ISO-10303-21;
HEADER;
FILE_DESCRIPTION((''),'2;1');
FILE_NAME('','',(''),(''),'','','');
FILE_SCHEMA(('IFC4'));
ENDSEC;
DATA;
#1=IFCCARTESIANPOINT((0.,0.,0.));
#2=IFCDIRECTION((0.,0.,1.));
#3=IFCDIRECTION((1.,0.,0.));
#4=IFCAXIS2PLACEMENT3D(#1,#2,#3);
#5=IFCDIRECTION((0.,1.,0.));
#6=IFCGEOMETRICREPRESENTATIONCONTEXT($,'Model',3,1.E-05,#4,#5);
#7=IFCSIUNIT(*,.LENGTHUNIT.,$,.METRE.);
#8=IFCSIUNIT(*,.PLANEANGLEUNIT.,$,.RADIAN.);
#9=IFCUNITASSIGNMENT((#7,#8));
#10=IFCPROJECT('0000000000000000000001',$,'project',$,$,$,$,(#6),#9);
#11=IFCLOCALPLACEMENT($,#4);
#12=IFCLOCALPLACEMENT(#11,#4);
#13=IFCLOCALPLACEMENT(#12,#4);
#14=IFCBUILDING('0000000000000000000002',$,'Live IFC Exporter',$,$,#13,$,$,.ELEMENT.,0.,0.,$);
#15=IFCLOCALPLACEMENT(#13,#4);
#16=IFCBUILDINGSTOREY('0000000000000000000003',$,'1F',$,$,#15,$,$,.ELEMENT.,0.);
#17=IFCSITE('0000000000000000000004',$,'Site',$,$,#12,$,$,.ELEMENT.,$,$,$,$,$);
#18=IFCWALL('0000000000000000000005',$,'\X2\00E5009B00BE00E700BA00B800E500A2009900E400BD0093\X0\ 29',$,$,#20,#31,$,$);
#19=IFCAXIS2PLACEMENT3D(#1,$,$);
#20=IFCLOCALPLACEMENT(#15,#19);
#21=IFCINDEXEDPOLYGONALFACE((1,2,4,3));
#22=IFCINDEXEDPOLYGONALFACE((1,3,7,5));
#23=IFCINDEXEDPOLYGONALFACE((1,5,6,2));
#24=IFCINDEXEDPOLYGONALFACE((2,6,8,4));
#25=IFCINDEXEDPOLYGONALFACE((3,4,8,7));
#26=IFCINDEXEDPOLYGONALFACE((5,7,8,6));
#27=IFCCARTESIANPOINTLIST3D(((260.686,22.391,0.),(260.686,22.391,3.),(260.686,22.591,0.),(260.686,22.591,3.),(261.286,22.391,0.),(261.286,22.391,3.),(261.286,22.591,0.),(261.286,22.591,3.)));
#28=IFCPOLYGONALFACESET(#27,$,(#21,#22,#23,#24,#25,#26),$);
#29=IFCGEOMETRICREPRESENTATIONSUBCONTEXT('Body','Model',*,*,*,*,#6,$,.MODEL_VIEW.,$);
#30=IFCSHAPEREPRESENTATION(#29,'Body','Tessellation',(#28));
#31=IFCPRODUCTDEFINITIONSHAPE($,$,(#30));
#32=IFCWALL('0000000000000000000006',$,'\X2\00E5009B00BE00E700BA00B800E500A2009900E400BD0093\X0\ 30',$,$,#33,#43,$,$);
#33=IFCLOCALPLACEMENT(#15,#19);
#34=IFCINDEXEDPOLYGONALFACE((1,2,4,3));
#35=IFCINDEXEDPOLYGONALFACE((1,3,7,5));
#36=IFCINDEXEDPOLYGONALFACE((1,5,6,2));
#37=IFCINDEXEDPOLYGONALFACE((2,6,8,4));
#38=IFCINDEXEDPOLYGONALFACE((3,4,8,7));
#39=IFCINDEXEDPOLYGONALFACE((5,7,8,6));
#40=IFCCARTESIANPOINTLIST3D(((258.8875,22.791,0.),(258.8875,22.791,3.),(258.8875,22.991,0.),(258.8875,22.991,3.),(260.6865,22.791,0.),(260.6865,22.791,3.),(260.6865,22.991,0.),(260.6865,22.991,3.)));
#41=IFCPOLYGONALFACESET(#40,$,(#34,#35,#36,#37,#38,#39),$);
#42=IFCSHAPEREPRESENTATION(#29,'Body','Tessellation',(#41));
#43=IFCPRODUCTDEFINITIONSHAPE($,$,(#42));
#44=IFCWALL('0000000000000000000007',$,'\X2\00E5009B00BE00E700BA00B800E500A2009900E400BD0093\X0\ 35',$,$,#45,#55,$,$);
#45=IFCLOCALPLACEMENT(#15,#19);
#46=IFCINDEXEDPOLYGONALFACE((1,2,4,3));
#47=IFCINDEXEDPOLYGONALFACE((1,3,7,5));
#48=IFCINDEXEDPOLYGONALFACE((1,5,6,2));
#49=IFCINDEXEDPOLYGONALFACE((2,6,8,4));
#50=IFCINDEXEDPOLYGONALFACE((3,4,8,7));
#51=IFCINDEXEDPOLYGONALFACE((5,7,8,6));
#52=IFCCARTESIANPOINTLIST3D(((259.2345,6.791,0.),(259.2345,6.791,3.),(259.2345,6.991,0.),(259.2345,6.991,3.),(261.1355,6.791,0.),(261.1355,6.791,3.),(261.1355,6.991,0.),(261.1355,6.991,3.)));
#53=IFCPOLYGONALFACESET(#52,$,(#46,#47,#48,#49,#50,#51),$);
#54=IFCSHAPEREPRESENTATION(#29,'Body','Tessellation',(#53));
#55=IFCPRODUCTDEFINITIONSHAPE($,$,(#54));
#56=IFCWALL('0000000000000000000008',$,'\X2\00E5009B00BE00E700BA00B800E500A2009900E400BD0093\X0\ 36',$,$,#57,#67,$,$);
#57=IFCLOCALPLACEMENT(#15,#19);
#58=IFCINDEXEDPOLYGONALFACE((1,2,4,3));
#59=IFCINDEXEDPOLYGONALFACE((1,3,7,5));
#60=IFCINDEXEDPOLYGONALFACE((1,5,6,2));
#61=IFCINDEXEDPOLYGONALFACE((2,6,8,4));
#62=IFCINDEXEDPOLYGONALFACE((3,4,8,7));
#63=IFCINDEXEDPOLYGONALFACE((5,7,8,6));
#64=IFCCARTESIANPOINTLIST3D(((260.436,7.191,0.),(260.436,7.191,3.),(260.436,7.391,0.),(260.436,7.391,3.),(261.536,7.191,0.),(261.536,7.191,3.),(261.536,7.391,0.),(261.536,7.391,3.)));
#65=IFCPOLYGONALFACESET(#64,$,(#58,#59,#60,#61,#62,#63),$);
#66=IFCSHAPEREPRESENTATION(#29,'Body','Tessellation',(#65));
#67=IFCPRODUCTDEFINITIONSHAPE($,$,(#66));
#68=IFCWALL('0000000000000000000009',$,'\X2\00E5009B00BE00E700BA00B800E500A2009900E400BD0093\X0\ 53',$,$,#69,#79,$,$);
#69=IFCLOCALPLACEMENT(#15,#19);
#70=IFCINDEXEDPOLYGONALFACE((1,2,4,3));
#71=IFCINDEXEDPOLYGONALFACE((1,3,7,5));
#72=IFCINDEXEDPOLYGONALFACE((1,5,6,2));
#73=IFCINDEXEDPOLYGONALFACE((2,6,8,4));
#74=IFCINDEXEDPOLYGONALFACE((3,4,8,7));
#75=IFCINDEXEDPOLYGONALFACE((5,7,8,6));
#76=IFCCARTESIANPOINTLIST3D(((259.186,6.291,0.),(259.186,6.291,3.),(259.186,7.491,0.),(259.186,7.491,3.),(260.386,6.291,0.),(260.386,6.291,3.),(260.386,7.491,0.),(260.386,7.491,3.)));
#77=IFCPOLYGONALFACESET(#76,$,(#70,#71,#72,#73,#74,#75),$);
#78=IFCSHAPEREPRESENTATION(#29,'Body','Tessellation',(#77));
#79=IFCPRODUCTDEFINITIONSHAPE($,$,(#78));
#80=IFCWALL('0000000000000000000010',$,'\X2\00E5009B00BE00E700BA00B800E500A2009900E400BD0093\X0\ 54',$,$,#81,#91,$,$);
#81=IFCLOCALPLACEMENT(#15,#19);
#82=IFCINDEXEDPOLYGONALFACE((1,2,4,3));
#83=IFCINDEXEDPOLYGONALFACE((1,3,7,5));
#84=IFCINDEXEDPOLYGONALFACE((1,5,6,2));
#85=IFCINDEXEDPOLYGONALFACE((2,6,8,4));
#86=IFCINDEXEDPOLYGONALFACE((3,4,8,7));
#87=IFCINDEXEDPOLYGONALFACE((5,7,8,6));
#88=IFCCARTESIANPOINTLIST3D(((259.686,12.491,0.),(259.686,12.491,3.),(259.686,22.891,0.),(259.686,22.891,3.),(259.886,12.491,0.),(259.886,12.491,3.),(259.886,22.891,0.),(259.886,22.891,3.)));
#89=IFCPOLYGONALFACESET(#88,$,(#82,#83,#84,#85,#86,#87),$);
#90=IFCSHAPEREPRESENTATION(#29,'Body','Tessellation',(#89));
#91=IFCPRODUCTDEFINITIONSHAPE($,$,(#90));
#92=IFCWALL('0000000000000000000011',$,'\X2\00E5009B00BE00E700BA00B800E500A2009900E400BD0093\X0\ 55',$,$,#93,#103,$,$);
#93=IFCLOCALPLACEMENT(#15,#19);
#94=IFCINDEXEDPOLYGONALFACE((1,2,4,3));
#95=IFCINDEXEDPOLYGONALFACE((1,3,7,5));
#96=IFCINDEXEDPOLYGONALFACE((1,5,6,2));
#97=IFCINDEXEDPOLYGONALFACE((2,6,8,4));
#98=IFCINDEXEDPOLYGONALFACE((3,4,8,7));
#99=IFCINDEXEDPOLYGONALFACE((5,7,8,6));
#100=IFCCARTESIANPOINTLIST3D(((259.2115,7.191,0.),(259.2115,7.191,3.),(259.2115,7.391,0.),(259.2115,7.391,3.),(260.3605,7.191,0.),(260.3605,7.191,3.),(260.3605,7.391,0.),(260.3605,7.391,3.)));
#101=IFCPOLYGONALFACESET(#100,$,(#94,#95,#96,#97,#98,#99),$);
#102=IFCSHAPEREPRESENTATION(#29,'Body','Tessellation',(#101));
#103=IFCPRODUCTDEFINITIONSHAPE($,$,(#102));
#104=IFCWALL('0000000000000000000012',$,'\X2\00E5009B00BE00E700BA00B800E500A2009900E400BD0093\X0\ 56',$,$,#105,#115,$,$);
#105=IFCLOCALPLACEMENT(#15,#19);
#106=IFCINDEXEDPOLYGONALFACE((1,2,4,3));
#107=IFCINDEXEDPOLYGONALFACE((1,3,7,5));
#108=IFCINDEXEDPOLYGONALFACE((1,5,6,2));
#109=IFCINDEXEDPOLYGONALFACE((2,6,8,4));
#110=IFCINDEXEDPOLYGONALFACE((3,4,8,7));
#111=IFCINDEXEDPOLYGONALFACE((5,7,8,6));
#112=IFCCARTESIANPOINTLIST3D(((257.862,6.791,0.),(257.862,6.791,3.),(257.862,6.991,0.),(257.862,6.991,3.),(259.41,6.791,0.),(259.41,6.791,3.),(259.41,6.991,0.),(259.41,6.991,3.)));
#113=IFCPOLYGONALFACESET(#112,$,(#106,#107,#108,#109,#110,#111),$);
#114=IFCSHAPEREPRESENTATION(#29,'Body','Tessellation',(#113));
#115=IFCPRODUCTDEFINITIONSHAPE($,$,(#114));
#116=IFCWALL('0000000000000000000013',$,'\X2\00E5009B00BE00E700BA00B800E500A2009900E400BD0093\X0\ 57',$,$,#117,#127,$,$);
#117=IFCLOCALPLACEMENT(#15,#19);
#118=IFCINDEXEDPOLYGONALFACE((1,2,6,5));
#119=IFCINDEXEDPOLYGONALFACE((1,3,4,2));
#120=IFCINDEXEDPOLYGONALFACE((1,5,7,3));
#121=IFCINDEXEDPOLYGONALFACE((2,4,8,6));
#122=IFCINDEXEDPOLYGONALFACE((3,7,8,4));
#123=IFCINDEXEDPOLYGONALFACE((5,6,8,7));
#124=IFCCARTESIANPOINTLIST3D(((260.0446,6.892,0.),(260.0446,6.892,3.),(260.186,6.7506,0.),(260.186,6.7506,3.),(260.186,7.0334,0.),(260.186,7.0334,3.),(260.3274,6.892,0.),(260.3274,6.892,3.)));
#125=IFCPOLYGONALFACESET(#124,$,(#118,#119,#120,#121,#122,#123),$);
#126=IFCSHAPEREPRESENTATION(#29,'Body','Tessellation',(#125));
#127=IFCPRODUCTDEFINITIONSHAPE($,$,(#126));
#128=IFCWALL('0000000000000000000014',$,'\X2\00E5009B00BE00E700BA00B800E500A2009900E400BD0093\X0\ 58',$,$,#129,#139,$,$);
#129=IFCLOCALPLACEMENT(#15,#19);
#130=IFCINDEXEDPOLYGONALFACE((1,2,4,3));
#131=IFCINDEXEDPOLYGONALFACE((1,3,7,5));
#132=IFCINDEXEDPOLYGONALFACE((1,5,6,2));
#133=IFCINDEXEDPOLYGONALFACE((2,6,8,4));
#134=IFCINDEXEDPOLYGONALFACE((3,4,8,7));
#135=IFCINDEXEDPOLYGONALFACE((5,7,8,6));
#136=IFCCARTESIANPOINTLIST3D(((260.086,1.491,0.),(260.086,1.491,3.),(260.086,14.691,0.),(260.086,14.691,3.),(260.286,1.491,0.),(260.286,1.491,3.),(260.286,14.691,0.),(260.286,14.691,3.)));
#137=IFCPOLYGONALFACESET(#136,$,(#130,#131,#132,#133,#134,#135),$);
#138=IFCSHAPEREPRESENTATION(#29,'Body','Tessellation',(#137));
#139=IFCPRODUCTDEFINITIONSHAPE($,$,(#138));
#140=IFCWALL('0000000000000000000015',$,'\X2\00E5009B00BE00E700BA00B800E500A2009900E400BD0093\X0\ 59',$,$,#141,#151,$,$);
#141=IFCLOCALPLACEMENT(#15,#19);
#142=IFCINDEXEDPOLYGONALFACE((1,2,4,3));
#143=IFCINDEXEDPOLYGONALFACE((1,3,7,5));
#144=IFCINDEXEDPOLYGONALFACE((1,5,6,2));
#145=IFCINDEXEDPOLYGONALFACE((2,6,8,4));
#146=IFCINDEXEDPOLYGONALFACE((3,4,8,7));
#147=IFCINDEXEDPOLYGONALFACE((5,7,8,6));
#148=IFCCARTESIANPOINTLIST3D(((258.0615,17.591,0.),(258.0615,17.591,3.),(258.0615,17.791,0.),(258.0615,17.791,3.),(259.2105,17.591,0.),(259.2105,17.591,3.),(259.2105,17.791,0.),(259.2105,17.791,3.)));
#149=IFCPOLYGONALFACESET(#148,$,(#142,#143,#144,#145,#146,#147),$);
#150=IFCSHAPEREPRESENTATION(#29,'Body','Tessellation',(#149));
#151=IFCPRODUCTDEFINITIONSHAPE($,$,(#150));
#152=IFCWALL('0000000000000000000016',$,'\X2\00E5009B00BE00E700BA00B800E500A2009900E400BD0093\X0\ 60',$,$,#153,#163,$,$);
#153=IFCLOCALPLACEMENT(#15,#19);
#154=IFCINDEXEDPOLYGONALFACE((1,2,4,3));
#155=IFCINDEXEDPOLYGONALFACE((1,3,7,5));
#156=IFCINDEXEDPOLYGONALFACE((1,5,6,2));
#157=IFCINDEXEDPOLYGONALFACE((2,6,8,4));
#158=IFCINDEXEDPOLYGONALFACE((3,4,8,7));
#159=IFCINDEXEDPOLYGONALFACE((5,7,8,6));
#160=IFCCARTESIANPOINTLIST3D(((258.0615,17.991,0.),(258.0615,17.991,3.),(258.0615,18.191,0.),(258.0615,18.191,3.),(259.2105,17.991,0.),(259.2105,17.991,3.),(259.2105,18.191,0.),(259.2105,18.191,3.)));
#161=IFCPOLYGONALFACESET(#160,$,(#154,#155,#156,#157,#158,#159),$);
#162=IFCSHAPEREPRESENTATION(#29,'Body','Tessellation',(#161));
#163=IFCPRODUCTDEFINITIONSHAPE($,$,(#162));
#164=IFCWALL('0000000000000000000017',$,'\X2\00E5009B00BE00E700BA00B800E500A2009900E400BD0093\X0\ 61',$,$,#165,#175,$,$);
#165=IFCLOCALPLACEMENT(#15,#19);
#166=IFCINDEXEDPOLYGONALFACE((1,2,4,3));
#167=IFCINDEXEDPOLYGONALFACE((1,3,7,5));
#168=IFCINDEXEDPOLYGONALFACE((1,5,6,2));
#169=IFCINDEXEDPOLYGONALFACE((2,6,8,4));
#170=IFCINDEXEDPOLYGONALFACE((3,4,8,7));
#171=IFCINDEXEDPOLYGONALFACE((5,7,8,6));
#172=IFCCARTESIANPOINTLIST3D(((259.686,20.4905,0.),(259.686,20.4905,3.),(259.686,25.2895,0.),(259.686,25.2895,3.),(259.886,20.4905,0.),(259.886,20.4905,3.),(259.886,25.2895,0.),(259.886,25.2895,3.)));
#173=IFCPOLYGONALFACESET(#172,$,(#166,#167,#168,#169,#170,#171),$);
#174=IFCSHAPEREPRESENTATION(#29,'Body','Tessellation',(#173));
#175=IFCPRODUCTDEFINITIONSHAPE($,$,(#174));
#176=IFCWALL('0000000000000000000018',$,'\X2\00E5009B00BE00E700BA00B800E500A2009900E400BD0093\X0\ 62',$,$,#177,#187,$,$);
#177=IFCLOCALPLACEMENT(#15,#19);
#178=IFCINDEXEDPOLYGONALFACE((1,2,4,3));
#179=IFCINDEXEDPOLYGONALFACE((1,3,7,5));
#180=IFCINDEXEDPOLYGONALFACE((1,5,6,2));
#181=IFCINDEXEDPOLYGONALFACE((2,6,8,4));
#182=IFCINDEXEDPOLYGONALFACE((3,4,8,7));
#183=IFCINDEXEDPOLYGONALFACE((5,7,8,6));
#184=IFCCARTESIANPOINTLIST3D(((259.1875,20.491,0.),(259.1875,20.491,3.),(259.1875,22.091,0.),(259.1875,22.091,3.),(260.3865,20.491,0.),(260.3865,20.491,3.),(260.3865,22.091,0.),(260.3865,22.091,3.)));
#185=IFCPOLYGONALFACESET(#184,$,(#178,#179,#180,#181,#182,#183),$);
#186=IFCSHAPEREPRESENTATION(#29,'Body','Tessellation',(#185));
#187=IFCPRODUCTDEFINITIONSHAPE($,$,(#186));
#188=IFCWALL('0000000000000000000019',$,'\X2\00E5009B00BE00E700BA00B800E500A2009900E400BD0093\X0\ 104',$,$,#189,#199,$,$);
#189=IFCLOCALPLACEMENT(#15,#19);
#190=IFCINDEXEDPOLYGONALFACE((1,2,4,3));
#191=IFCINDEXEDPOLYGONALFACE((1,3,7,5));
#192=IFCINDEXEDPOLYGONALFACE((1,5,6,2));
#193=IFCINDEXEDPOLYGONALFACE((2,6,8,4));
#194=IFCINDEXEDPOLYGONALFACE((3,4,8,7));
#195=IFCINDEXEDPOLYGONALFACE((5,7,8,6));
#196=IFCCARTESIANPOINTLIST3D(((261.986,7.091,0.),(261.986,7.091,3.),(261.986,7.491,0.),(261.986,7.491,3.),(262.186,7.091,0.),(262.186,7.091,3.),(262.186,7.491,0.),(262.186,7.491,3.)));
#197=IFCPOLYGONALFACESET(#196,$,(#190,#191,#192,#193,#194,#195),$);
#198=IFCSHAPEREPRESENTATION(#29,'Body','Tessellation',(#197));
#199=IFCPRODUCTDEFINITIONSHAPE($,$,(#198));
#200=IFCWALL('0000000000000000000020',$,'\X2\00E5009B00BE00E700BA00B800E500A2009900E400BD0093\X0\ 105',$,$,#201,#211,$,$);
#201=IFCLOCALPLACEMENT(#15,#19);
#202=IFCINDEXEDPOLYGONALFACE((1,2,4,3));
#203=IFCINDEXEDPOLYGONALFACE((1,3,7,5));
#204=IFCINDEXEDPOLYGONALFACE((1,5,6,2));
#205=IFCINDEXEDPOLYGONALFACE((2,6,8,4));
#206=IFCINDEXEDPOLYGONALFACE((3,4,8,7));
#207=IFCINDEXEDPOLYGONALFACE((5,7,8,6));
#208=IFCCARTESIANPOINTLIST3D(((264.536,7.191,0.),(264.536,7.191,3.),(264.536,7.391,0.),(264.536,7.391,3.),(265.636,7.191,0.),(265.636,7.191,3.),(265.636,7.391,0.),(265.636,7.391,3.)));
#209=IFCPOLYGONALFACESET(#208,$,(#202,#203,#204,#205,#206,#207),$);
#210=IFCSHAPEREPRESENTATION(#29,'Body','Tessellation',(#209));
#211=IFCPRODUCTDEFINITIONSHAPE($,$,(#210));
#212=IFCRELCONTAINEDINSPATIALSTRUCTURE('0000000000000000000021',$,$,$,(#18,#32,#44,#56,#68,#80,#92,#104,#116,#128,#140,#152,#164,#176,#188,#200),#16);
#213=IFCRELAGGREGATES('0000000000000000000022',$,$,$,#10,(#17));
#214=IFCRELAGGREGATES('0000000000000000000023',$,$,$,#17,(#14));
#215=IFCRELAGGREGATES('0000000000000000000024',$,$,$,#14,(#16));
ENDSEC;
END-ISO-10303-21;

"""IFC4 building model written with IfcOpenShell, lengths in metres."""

from ifc_helpers import new_model, si_unit, direction, frame, frame_2d, origin_with_axes, place, context, subcontext, project, spatial, rectangle, extrude, element, save


model = new_model("IFC4")

# Units and contexts
model_context = context("Model", 3, precision=1e-05, world=origin_with_axes(), true_north=direction((0.0, 1.0, 0.0)))
body_context = subcontext(model_context, "Body", "Model", "MODEL_VIEW")
ifc_project = project(units=[si_unit("LENGTHUNIT", "METRE"), si_unit("PLANEANGLEUNIT", "RADIAN")], contexts=[model_context])

# Site, building, storey
placement = place(None, origin_with_axes())
site_placement = place(placement, origin_with_axes())
site = spatial("IfcSite", under=ifc_project, at=site_placement, Name="Site", CompositionType="ELEMENT")
building_placement = place(site_placement, origin_with_axes())
building = spatial("IfcBuilding", under=site, at=building_placement, Name="Live IFC Exporter", CompositionType="ELEMENT", ElevationOfRefHeight=0.0, ElevationOfTerrain=0.0)
storey_placement = place(building_placement, origin_with_axes())
storey = spatial("IfcBuildingStorey", under=building, at=storey_placement, Name="1F", CompositionType="ELEMENT", Elevation=0.0)

# Walls
wall_1_placement = place(storey_placement, frame((260.986, 22.491, 0.0), z_axis=(0.0, 0.0, 1.0), x_axis=(1.0, 0.0, 0.0)))
element("IfcWall", 1, at=wall_1_placement, inside=storey, Name="å\u009b¾çº¸å¢\u0099ä½\u0093 29", context=body_context, shape_type="SweptSolid", body=[
    extrude(rectangle(XDim=0.6, YDim=0.2, at=frame_2d((0.0, 0.0), x_axis=(1.0, 0.0, 0.0))), frame((0.0, 0.0, 0.0), z_axis=(0.0, 0.0, 1.0)), (0.0, 0.0, 1.0), 3.0),
])
wall_2_placement = place(storey_placement, frame((259.787, 22.891, 0.0), z_axis=(0.0, 0.0, 1.0), x_axis=(1.0, 0.0, 0.0)))
element("IfcWall", 2, at=wall_2_placement, inside=storey, Name="å\u009b¾çº¸å¢\u0099ä½\u0093 30", context=body_context, shape_type="SweptSolid", body=[
    extrude(rectangle(XDim=1.799, YDim=0.2, at=frame_2d((0.0, 0.0), x_axis=(1.0, 0.0, 0.0))), frame((0.0, 0.0, 0.0), z_axis=(0.0, 0.0, 1.0)), (0.0, 0.0, 1.0), 3.0),
])
wall_3_placement = place(storey_placement, frame((260.185, 6.891, 0.0), z_axis=(0.0, 0.0, 1.0), x_axis=(1.0, 0.0, 0.0)))
element("IfcWall", 3, at=wall_3_placement, inside=storey, Name="å\u009b¾çº¸å¢\u0099ä½\u0093 35", context=body_context, shape_type="SweptSolid", body=[
    extrude(rectangle(XDim=1.901, YDim=0.2, at=frame_2d((0.0, 0.0), x_axis=(1.0, 0.0, 0.0))), frame((0.0, 0.0, 0.0), z_axis=(0.0, 0.0, 1.0)), (0.0, 0.0, 1.0), 3.0),
])
wall_4_placement = place(storey_placement, frame((260.986, 7.291, 0.0), z_axis=(0.0, 0.0, 1.0), x_axis=(1.0, 0.0, 0.0)))
element("IfcWall", 4, at=wall_4_placement, inside=storey, Name="å\u009b¾çº¸å¢\u0099ä½\u0093 36", context=body_context, shape_type="SweptSolid", body=[
    extrude(rectangle(XDim=1.1, YDim=0.2, at=frame_2d((0.0, 0.0), x_axis=(1.0, 0.0, 0.0))), frame((0.0, 0.0, 0.0), z_axis=(0.0, 0.0, 1.0)), (0.0, 0.0, 1.0), 3.0),
])
wall_5_placement = place(storey_placement, frame((259.786, 6.891, 0.0), z_axis=(0.0, 0.0, 1.0), x_axis=(1.0, 0.0, 0.0)))
element("IfcWall", 5, at=wall_5_placement, inside=storey, Name="å\u009b¾çº¸å¢\u0099ä½\u0093 53", context=body_context, shape_type="SweptSolid", body=[
    extrude(rectangle(XDim=1.2, YDim=1.2, at=frame_2d((0.0, 0.0), x_axis=(1.0, 0.0, 0.0))), frame((0.0, 0.0, 0.0), z_axis=(0.0, 0.0, 1.0)), (0.0, 0.0, 1.0), 3.0),
])
wall_6_placement = place(storey_placement, frame((259.786, 17.691, 0.0), z_axis=(0.0, 0.0, 1.0), x_axis=(0.0, -1.0, 0.0)))
element("IfcWall", 6, at=wall_6_placement, inside=storey, Name="å\u009b¾çº¸å¢\u0099ä½\u0093 54", context=body_context, shape_type="SweptSolid", body=[
    extrude(rectangle(XDim=10.4, YDim=0.2, at=frame_2d((0.0, 0.0), x_axis=(1.0, 0.0, 0.0))), frame((0.0, 0.0, 0.0), z_axis=(0.0, 0.0, 1.0)), (0.0, 0.0, 1.0), 3.0),
])
wall_7_placement = place(storey_placement, frame((259.786, 7.291, 0.0), z_axis=(0.0, 0.0, 1.0), x_axis=(-1.0, 0.0, 0.0)))
element("IfcWall", 7, at=wall_7_placement, inside=storey, Name="å\u009b¾çº¸å¢\u0099ä½\u0093 55", context=body_context, shape_type="SweptSolid", body=[
    extrude(rectangle(XDim=1.149, YDim=0.2, at=frame_2d((0.0, 0.0), x_axis=(1.0, 0.0, 0.0))), frame((0.0, 0.0, 0.0), z_axis=(0.0, 0.0, 1.0)), (0.0, 0.0, 1.0), 3.0),
])
wall_8_placement = place(storey_placement, frame((258.636, 6.891, 0.0), z_axis=(0.0, 0.0, 1.0), x_axis=(1.0, 0.0, 0.0)))
element("IfcWall", 8, at=wall_8_placement, inside=storey, Name="å\u009b¾çº¸å¢\u0099ä½\u0093 56", context=body_context, shape_type="SweptSolid", body=[
    extrude(rectangle(XDim=1.548, YDim=0.2, at=frame_2d((0.0, 0.0), x_axis=(1.0, 0.0, 0.0))), frame((0.0, 0.0, 0.0), z_axis=(0.0, 0.0, 1.0)), (0.0, 0.0, 1.0), 3.0),
])
wall_9_placement = place(storey_placement, frame((260.186, 6.892, 0.0), z_axis=(0.0, 0.0, 1.0), x_axis=(-0.707107, -0.707107, 0.0)))
element("IfcWall", 9, at=wall_9_placement, inside=storey, Name="å\u009b¾çº¸å¢\u0099ä½\u0093 57", context=body_context, shape_type="SweptSolid", body=[
    extrude(rectangle(XDim=0.2, YDim=0.2, at=frame_2d((0.0, 0.0), x_axis=(1.0, 0.0, 0.0))), frame((0.0, 0.0, 0.0), z_axis=(0.0, 0.0, 1.0)), (0.0, 0.0, 1.0), 3.0),
])
wall_10_placement = place(storey_placement, frame((260.186, 8.091, 0.0), z_axis=(0.0, 0.0, 1.0), x_axis=(0.0, 1.0, 0.0)))
element("IfcWall", 10, at=wall_10_placement, inside=storey, Name="å\u009b¾çº¸å¢\u0099ä½\u0093 58", context=body_context, shape_type="SweptSolid", body=[
    extrude(rectangle(XDim=13.2, YDim=0.2, at=frame_2d((0.0, 0.0), x_axis=(1.0, 0.0, 0.0))), frame((0.0, 0.0, 0.0), z_axis=(0.0, 0.0, 1.0)), (0.0, 0.0, 1.0), 3.0),
])
for number, where, z_axis, x_axis, name in (
    (11, (258.636, 17.691, 0.0), (0.0, 0.0, 1.0), (1.0, 0.0, 0.0), "å\u009b¾çº¸å¢\u0099ä½\u0093 59"),
    (12, (258.636, 18.091, 0.0), (0.0, 0.0, 1.0), (1.0, 0.0, 0.0), "å\u009b¾çº¸å¢\u0099ä½\u0093 60"),
):
    element("IfcWall", number, at=place(storey_placement, frame(where, z_axis=z_axis, x_axis=x_axis)), inside=storey, Name=name, context=body_context, shape_type="SweptSolid", body=[
        extrude(rectangle(XDim=1.149, YDim=0.2, at=frame_2d((0.0, 0.0), x_axis=(1.0, 0.0, 0.0))), frame((0.0, 0.0, 0.0), z_axis=(0.0, 0.0, 1.0)), (0.0, 0.0, 1.0), 3.0),
    ])
wall_11_placement = place(storey_placement, frame((259.786, 22.89, 0.0), z_axis=(0.0, 0.0, 1.0), x_axis=(0.0, -1.0, 0.0)))
element("IfcWall", 13, at=wall_11_placement, inside=storey, Name="å\u009b¾çº¸å¢\u0099ä½\u0093 61", context=body_context, shape_type="SweptSolid", body=[
    extrude(rectangle(XDim=4.799, YDim=0.2, at=frame_2d((0.0, 0.0), x_axis=(1.0, 0.0, 0.0))), frame((0.0, 0.0, 0.0), z_axis=(0.0, 0.0, 1.0)), (0.0, 0.0, 1.0), 3.0),
])
wall_12_placement = place(storey_placement, frame((259.787, 21.291, 0.0), z_axis=(0.0, 0.0, 1.0), x_axis=(1.0, 0.0, 0.0)))
element("IfcWall", 14, at=wall_12_placement, inside=storey, Name="å\u009b¾çº¸å¢\u0099ä½\u0093 62", context=body_context, shape_type="SweptSolid", body=[
    extrude(rectangle(XDim=1.199, YDim=1.6, at=frame_2d((0.0, 0.0), x_axis=(1.0, 0.0, 0.0))), frame((0.0, 0.0, 0.0), z_axis=(0.0, 0.0, 1.0)), (0.0, 0.0, 1.0), 3.0),
])
wall_13_placement = place(storey_placement, frame((262.086, 7.291, 0.0), z_axis=(0.0, 0.0, 1.0), x_axis=(0.0, -1.0, 0.0)))
element("IfcWall", 15, at=wall_13_placement, inside=storey, Name="å\u009b¾çº¸å¢\u0099ä½\u0093 104", context=body_context, shape_type="SweptSolid", body=[
    extrude(rectangle(XDim=0.4, YDim=0.2, at=frame_2d((0.0, 0.0), x_axis=(1.0, 0.0, 0.0))), frame((0.0, 0.0, 0.0), z_axis=(0.0, 0.0, 1.0)), (0.0, 0.0, 1.0), 3.0),
])
wall_14_placement = place(storey_placement, frame((265.086, 7.291, 0.0), z_axis=(0.0, 0.0, 1.0), x_axis=(1.0, 0.0, 0.0)))
element("IfcWall", 16, at=wall_14_placement, inside=storey, Name="å\u009b¾çº¸å¢\u0099ä½\u0093 105", context=body_context, shape_type="SweptSolid", body=[
    extrude(rectangle(XDim=1.1, YDim=0.2, at=frame_2d((0.0, 0.0), x_axis=(1.0, 0.0, 0.0))), frame((0.0, 0.0, 0.0), z_axis=(0.0, 0.0, 1.0)), (0.0, 0.0, 1.0), 3.0),
])

save(model, "model.ifc")
